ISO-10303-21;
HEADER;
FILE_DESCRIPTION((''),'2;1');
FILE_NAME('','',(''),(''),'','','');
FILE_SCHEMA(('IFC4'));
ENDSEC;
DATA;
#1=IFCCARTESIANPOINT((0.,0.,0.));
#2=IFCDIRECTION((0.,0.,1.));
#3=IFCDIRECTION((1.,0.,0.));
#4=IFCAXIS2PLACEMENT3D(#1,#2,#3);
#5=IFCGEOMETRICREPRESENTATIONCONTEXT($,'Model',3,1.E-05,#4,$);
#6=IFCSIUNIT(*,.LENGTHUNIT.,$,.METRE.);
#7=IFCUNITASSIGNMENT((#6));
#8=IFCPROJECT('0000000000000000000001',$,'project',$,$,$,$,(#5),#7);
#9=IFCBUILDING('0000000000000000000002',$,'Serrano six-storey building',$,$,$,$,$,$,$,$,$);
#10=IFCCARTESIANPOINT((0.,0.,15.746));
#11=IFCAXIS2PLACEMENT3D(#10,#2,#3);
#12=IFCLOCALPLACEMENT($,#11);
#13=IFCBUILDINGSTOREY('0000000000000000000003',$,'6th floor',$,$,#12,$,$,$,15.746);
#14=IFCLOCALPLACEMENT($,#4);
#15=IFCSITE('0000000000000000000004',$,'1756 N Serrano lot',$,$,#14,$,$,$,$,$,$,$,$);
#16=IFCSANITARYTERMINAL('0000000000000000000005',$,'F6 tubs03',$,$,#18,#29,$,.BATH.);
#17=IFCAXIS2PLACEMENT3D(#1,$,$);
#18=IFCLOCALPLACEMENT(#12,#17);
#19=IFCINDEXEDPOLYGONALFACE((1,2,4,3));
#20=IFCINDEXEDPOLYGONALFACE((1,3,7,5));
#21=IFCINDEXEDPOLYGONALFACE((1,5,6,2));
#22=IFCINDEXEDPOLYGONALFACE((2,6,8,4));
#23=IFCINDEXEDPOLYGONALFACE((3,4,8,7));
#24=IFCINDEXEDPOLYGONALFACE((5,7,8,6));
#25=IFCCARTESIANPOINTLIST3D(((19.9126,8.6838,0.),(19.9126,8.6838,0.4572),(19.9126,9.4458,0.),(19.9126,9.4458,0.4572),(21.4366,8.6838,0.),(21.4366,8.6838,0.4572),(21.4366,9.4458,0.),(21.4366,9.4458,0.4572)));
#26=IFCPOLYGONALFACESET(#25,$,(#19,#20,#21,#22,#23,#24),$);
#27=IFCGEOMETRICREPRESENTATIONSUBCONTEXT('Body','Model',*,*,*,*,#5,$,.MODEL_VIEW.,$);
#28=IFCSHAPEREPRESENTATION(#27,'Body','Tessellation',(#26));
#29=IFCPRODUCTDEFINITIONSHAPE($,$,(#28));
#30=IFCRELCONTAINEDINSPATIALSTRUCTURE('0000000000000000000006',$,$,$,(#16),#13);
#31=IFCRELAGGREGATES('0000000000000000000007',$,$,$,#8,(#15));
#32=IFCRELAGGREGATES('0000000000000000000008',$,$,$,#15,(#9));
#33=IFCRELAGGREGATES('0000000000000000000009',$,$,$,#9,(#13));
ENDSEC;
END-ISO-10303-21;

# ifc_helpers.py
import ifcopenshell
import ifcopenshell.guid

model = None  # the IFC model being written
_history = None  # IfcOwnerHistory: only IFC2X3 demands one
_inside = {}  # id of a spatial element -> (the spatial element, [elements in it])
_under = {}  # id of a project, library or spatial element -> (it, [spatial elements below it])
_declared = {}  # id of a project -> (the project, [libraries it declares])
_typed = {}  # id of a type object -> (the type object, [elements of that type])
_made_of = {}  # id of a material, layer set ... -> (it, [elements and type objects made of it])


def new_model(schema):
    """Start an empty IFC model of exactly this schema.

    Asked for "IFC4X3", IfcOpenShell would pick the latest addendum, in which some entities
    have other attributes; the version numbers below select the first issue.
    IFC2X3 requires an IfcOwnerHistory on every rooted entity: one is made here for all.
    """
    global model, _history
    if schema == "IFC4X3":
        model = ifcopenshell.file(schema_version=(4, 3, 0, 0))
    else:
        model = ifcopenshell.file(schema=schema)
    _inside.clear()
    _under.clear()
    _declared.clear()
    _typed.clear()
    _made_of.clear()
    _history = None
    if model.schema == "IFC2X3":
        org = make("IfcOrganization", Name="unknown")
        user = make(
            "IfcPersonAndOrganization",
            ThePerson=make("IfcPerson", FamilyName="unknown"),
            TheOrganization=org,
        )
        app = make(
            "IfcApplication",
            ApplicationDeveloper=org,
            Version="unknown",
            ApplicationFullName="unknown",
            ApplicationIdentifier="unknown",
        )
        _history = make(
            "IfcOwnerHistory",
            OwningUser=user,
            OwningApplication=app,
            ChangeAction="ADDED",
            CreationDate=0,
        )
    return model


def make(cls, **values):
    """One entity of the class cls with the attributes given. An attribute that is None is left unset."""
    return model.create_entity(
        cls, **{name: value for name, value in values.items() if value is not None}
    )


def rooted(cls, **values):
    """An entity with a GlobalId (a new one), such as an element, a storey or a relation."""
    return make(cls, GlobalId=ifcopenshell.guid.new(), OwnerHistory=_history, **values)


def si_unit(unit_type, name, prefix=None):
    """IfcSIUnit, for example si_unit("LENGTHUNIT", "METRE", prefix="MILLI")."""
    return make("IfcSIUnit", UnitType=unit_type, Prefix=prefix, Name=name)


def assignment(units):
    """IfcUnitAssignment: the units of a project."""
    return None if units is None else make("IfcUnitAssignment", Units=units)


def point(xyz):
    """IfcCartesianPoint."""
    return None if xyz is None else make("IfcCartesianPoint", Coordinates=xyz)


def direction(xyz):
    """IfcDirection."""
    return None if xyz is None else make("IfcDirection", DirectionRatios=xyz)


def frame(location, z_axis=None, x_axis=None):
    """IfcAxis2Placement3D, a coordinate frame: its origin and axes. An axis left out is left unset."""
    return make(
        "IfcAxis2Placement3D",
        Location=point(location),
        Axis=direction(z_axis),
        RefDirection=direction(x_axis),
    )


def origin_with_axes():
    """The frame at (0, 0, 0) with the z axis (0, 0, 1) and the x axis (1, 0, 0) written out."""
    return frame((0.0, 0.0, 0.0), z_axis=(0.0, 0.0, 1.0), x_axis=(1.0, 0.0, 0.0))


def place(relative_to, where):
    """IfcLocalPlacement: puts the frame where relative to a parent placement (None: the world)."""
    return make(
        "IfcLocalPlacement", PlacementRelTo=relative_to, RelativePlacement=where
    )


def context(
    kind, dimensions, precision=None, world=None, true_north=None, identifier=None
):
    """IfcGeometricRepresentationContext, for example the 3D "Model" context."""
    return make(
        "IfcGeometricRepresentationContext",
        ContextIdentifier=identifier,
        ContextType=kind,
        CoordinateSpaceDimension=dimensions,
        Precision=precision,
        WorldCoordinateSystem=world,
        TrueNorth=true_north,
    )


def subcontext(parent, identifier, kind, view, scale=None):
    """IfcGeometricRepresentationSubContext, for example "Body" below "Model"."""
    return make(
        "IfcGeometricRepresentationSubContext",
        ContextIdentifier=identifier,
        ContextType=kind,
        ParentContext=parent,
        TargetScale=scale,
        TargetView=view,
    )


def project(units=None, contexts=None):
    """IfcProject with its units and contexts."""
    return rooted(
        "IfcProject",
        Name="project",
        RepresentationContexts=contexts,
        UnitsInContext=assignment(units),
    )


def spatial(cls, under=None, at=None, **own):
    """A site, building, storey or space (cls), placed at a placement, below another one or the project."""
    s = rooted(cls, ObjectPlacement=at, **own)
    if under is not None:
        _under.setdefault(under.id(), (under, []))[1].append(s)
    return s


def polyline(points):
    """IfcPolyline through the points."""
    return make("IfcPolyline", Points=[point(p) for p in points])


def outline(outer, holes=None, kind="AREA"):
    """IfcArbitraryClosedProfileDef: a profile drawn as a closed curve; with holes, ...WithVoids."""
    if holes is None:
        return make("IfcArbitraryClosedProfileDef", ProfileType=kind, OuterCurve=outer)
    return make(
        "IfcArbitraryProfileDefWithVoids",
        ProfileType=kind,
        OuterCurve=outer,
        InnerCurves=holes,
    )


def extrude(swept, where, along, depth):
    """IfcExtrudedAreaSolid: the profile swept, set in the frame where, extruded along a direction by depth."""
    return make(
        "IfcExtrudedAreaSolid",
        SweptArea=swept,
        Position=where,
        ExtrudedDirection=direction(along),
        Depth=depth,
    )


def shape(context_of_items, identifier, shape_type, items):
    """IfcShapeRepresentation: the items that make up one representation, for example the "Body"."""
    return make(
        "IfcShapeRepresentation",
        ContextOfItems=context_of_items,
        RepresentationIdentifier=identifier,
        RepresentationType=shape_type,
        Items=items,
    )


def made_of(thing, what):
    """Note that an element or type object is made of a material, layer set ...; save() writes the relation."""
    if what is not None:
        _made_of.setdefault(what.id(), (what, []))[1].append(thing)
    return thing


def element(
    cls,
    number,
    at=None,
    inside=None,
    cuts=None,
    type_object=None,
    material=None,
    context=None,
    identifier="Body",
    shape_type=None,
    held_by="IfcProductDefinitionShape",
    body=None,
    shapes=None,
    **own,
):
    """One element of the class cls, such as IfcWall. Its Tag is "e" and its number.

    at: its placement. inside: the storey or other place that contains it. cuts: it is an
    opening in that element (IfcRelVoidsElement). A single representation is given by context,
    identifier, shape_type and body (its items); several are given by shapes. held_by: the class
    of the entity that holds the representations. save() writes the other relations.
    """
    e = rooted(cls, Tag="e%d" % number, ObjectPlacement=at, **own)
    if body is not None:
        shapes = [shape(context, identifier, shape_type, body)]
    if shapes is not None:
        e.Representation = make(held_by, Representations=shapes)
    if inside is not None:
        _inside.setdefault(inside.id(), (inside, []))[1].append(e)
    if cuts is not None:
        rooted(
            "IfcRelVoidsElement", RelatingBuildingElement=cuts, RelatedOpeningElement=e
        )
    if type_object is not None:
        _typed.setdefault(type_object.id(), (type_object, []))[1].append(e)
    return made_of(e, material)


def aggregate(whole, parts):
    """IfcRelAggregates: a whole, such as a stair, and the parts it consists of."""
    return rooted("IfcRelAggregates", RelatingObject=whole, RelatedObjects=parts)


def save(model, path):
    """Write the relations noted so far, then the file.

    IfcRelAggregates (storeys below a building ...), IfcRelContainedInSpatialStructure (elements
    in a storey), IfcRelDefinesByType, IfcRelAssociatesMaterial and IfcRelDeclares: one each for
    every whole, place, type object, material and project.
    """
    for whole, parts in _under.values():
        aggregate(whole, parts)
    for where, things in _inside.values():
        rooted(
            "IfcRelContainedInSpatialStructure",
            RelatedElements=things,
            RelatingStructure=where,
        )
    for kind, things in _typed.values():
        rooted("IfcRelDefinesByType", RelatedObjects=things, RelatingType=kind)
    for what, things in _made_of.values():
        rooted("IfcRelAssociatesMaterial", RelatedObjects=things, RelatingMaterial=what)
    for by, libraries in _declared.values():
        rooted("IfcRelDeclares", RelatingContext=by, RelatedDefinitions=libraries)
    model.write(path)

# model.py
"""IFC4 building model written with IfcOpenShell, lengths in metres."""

from ifc_helpers import new_model, si_unit, frame, origin_with_axes, place, context, subcontext, project, spatial, polyline, outline, extrude, element, save


model = new_model("IFC4")

# Units and contexts
model_context = context("Model", 3, precision=1e-05, world=origin_with_axes())
body_context = subcontext(model_context, "Body", "Model", "MODEL_VIEW")
ifc_project = project(units=[si_unit("LENGTHUNIT", "METRE")], contexts=[model_context])

# Site, building, storey
site_placement = place(None, origin_with_axes())
site = spatial("IfcSite", under=ifc_project, at=site_placement, Name="1756 N Serrano lot")
building = spatial("IfcBuilding", under=site, Name="Serrano six-storey building")
storey_placement = place(None, frame((0.0, 0.0, 15.746), z_axis=(0.0, 0.0, 1.0), x_axis=(1.0, 0.0, 0.0)))
storey = spatial("IfcBuildingStorey", under=building, at=storey_placement, Name="6th floor", Elevation=15.746)

# Sanitary terminal
sanitary_terminal_1_placement = place(storey_placement, frame((0.0, 0.0, -15.746), z_axis=(0.0, 0.0, 1.0), x_axis=(1.0, 0.0, 0.0)))
element("IfcSanitaryTerminal", 1, at=sanitary_terminal_1_placement, inside=storey, Name="F6 tubs03", PredefinedType="BATH", context=body_context, shape_type="SweptSolid", body=[
    extrude(outline(polyline([(21.4366, 8.6838), (21.4366, 9.4458), (19.9126, 9.4458), (19.9126, 8.6838), (21.4366, 8.6838)])), frame((0.0, 0.0, 15.746)), (0.0, 0.0, 1.0), 0.4572),
])

save(model, "model.ifc")
